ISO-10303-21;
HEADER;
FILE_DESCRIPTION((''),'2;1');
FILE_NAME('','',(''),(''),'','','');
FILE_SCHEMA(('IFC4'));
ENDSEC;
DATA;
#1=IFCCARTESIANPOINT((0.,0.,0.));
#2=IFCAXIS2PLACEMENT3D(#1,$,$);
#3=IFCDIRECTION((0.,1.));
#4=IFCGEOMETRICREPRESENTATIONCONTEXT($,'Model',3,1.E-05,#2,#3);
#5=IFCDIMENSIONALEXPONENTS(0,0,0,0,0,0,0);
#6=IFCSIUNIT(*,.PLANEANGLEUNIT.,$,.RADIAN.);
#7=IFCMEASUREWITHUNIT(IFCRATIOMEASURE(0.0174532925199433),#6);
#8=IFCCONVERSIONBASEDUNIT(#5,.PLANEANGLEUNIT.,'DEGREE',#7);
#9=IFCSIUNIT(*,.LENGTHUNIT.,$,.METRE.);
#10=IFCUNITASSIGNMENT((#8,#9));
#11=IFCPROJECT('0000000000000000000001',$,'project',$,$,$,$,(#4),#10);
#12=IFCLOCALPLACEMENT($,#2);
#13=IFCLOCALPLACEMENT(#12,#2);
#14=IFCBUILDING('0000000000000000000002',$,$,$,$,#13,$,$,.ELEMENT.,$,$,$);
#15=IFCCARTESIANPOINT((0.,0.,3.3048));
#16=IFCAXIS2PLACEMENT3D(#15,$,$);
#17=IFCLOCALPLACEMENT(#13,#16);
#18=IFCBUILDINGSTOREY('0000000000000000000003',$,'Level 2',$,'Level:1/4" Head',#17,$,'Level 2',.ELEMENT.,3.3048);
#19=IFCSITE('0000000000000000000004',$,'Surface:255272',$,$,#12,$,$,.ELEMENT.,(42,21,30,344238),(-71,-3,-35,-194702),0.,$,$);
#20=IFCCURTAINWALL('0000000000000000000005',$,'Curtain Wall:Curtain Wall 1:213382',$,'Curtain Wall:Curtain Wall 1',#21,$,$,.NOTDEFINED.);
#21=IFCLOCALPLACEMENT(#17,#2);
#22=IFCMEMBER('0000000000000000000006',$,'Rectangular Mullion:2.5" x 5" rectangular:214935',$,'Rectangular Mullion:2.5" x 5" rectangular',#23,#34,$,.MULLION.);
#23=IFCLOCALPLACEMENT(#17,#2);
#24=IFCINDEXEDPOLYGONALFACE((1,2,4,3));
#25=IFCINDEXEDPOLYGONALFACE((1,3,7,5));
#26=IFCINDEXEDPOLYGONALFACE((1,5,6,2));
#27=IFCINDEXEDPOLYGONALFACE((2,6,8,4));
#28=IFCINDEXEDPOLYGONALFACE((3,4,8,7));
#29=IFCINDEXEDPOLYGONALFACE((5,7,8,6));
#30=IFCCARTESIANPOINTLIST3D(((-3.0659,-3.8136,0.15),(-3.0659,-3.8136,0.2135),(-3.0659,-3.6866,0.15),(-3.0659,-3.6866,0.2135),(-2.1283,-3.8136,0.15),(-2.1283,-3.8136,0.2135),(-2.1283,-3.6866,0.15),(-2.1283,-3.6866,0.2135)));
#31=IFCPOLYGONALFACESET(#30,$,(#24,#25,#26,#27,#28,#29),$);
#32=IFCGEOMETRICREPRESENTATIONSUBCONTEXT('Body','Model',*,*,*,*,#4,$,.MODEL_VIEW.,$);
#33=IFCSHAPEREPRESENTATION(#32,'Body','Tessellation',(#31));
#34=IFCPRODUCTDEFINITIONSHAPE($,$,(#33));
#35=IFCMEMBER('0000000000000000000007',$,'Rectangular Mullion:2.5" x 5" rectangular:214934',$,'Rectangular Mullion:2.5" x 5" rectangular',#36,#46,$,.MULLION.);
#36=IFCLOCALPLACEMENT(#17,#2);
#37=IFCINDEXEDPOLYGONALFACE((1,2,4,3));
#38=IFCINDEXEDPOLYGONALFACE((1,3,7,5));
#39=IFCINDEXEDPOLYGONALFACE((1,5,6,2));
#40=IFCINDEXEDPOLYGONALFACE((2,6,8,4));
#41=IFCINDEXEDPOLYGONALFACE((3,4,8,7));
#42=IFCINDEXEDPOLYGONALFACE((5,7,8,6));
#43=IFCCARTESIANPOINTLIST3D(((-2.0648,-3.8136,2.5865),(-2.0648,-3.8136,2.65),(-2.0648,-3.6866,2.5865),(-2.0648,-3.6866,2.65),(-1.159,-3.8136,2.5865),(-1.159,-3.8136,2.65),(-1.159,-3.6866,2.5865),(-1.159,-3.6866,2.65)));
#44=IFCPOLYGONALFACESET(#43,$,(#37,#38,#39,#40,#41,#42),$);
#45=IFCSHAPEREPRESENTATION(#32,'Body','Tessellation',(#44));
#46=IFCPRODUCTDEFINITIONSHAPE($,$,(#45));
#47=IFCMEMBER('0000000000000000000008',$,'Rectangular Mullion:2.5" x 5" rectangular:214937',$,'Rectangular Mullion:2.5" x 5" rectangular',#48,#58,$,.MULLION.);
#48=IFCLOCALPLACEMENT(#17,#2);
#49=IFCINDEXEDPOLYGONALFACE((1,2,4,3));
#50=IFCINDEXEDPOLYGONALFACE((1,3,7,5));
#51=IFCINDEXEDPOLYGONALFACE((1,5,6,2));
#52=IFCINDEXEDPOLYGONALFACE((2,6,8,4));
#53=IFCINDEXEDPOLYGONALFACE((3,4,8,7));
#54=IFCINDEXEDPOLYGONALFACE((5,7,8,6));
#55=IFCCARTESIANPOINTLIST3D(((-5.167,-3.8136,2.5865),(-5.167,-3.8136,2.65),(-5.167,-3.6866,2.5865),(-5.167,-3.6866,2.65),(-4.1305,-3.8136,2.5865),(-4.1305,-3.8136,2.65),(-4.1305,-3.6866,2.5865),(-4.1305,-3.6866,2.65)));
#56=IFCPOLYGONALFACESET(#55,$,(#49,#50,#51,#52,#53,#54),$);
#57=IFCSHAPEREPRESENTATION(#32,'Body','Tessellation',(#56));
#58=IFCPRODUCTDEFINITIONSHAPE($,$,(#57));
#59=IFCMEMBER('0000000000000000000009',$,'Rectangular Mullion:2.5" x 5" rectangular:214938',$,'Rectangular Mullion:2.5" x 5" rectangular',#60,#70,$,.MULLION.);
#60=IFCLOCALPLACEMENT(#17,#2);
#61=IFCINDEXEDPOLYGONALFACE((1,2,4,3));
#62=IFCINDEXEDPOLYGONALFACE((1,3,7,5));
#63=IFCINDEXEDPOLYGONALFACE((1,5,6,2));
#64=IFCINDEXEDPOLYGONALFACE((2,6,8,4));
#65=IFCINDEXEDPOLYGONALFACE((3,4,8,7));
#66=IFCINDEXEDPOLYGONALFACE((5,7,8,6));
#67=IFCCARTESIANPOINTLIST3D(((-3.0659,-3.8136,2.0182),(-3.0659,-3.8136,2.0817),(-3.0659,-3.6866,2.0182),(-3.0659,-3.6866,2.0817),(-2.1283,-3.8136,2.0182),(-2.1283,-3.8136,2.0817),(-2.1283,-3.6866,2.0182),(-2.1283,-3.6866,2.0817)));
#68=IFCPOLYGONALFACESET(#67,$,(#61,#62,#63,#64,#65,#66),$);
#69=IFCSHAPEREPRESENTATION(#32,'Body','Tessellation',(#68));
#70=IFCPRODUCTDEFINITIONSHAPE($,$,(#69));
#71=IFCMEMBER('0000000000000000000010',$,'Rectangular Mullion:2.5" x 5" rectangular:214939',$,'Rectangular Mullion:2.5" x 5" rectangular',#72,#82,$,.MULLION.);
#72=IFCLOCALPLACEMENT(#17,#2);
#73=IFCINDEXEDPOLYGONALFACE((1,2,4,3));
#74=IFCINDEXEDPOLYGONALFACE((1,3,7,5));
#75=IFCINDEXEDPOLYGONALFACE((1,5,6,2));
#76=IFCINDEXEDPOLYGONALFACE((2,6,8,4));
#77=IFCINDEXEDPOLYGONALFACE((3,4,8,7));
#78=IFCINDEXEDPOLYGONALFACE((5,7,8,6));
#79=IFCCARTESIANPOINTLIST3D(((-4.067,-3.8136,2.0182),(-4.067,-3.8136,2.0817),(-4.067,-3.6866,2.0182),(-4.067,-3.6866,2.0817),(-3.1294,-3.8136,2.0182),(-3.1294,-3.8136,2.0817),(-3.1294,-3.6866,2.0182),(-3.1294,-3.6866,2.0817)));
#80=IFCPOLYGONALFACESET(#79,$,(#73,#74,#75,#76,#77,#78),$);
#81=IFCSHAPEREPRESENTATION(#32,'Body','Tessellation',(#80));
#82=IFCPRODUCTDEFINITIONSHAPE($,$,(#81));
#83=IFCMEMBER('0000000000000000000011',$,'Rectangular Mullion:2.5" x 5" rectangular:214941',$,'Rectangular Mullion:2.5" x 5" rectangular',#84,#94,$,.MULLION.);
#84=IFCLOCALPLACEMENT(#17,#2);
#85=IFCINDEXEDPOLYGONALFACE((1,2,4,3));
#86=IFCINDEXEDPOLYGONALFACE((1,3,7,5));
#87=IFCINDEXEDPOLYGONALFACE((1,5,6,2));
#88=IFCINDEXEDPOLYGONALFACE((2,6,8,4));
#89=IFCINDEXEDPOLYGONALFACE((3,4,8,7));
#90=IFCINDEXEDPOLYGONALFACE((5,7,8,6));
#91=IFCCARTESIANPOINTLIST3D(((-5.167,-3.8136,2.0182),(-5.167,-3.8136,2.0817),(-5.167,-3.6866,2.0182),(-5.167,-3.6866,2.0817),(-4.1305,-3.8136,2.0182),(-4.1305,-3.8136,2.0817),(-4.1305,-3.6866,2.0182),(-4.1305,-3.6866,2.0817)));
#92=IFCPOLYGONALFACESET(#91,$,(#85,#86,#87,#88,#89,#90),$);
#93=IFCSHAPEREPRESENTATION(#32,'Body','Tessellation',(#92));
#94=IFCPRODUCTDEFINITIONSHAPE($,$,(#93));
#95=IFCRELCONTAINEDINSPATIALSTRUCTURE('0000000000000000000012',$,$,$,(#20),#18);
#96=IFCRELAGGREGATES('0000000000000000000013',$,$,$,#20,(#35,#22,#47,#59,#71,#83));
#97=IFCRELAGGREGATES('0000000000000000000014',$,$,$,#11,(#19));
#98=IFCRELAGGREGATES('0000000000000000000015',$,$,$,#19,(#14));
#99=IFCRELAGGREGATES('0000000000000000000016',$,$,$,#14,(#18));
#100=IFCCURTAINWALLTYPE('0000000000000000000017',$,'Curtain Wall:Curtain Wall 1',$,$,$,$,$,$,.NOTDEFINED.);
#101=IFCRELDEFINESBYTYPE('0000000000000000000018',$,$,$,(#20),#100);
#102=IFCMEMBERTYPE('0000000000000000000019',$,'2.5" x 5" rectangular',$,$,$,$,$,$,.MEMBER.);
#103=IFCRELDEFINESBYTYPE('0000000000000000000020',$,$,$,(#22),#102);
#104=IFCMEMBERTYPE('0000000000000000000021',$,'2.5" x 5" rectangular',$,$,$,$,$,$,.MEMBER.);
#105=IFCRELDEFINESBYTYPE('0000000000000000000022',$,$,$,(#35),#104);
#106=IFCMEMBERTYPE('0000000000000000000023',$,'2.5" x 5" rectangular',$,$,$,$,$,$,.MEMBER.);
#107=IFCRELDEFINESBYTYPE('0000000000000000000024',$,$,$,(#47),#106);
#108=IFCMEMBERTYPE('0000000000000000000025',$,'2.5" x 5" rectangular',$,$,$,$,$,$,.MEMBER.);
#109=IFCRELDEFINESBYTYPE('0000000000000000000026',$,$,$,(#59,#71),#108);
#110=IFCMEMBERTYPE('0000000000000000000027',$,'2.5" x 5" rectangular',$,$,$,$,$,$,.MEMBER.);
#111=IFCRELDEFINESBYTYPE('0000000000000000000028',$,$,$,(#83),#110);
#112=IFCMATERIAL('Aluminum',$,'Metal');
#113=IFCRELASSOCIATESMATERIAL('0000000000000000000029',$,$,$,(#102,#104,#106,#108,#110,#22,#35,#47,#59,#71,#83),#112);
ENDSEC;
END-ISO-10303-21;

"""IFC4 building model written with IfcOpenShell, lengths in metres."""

from ifc_helpers import new_model, entity, si_unit, converted_unit, direction, frame, origin, origin_2d_with_axis, place, context, subcontext, project, spatial, rectangle, extrude, source, transform, mapped, material, material_profile, profile_set, profile_usage, type_object, type_shapes, element, aggregate, save


model = new_model("IFC4")

# Units and contexts
model_context = context("Model", 3, precision=1e-05, world=origin(), true_north=direction((0.0, 1.0)))
body_context = subcontext(model_context, "Body", "Model", "MODEL_VIEW")
ifc_project = project(units=[converted_unit("PLANEANGLEUNIT", "DEGREE", entity("IfcRatioMeasure", 0.0174532925199433), si_unit("PLANEANGLEUNIT", "RADIAN"), dimensions=[0, 0, 0, 0, 0, 0, 0]), si_unit("LENGTHUNIT", "METRE")], contexts=[model_context])

# Site, building, storey
site_placement = place(None, origin())
site = spatial("IfcSite", under=ifc_project, at=site_placement, Name="Surface:255272", CompositionType="ELEMENT", RefLatitude=(42, 21, 30, 344238), RefLongitude=(-71, -3, -35, -194702), RefElevation=0.0)
building_placement = place(site_placement, origin())
building = spatial("IfcBuilding", under=site, at=building_placement, CompositionType="ELEMENT")
storey_placement = place(building_placement, frame((0.0, 0.0, 3.3048)))
storey = spatial("IfcBuildingStorey", under=building, at=storey_placement, Name="Level 2", ObjectType="Level:1/4\" Head", LongName="Level 2", CompositionType="ELEMENT", Elevation=3.3048)

# Curtain wall, members
curtain_wall_type = type_object("IfcCurtainWallType", Name="Curtain Wall:Curtain Wall 1", PredefinedType="NOTDEFINED")
curtain_wall_placement = place(storey_placement, frame((0.0, 0.0, -3.3048)))
curtain_wall = element("IfcCurtainWall", 1, at=curtain_wall_placement, inside=storey, type_object=curtain_wall_type, Name="Curtain Wall:Curtain Wall 1:213382", ObjectType="Curtain Wall:Curtain Wall 1", PredefinedType="NOTDEFINED")
ifc_material_1 = material(Name="Aluminum", Category="Metal")
ifc_material_profile = material_profile(ifc_material_1, rectangle(XDim=0.127, YDim=0.0635, at=origin_2d_with_axis()), Name="2.5\" x 5\" rectangular")
ifc_profile_set = profile_set([ifc_material_profile], Name="2.5\" x 5\" rectangular")
member_type_1 = type_object("IfcMemberType", Name="2.5\" x 5\" rectangular", PredefinedType="MEMBER", material=ifc_profile_set)
shared_shape_1 = source(origin(), body_context, "Body", "SweptSolid", [
    extrude(rectangle(XDim=0.127, YDim=0.0635, at=origin_2d_with_axis()), frame((-0.0318, 0.0, -0.9376), z_axis=(0.0, 0.0, 1.0), x_axis=(0.0, -1.0, 0.0)), (0.0, 0.0, 1.0), 0.9376),
])
type_shapes(member_type_1, [shared_shape_1])
ifc_profile_usage_1 = profile_usage(ifc_profile_set)
member_1_placement = place(storey_placement, frame((-2.1283, -3.7501, 0.15), z_axis=(1.0, -0.000007, 0.0), x_axis=(0.0, 0.0, -1.0)))
member_1 = element("IfcMember", 2, at=member_1_placement, type_object=member_type_1, material=ifc_profile_usage_1, Name="Rectangular Mullion:2.5\" x 5\" rectangular:214935", ObjectType="Rectangular Mullion:2.5\" x 5\" rectangular", PredefinedType="MULLION", context=body_context, shape_type="MappedRepresentation", body=[
    mapped(shared_shape_1, transform((0.0, 0.0, 0.0), scale=1.0)),
])
ifc_profile_usage_2 = profile_usage(ifc_profile_set)
member_type_2 = type_object("IfcMemberType", Name="2.5\" x 5\" rectangular", PredefinedType="MEMBER", material=ifc_profile_set)
shared_shape_2 = source(origin(), body_context, "Body", "SweptSolid", [
    extrude(rectangle(XDim=0.127, YDim=0.0635, at=origin_2d_with_axis()), frame((-0.0318, 0.0, -0.9058), z_axis=(0.0, 0.0, 1.0), x_axis=(0.0, -1.0, 0.0)), (0.0, 0.0, 1.0), 0.9058),
])
type_shapes(member_type_2, [shared_shape_2])
member_2_placement = place(storey_placement, frame((-2.0648, -3.7501, 2.65), z_axis=(-1.0, 0.000007, 0.0), x_axis=(0.0, 0.0, 1.0)))
member_2 = element("IfcMember", 3, at=member_2_placement, type_object=member_type_2, material=ifc_profile_usage_2, Name="Rectangular Mullion:2.5\" x 5\" rectangular:214934", ObjectType="Rectangular Mullion:2.5\" x 5\" rectangular", PredefinedType="MULLION", context=body_context, shape_type="MappedRepresentation", body=[
    mapped(shared_shape_2, transform((0.0, 0.0, 0.0), scale=1.0)),
])
ifc_profile_usage_3 = profile_usage(ifc_profile_set)
member_type_3 = type_object("IfcMemberType", Name="2.5\" x 5\" rectangular", PredefinedType="MEMBER", material=ifc_profile_set)
shared_shape_3 = source(origin(), body_context, "Body", "SweptSolid", [
    extrude(rectangle(XDim=0.127, YDim=0.0635, at=origin_2d_with_axis()), frame((-0.0318, 0.0, -1.0365), z_axis=(0.0, 0.0, 1.0), x_axis=(0.0, -1.0, 0.0)), (0.0, 0.0, 1.0), 1.0365),
])
type_shapes(member_type_3, [shared_shape_3])
member_3_placement = place(storey_placement, frame((-5.167, -3.7501, 2.65), z_axis=(-1.0, 0.000007, 0.0), x_axis=(0.0, 0.0, 1.0)))
member_3 = element("IfcMember", 4, at=member_3_placement, type_object=member_type_3, material=ifc_profile_usage_3, Name="Rectangular Mullion:2.5\" x 5\" rectangular:214937", ObjectType="Rectangular Mullion:2.5\" x 5\" rectangular", PredefinedType="MULLION", context=body_context, shape_type="MappedRepresentation", body=[
    mapped(shared_shape_3, transform((0.0, 0.0, 0.0), scale=1.0)),
])
ifc_profile_usage_4 = profile_usage(ifc_profile_set)
member_type_4 = type_object("IfcMemberType", Name="2.5\" x 5\" rectangular", PredefinedType="MEMBER", material=ifc_profile_set)
shared_shape_4 = source(origin(), body_context, "Body", "SweptSolid", [
    extrude(rectangle(XDim=0.127, YDim=0.0635, at=origin_2d_with_axis()), frame((0.0, 0.0, -0.9376), z_axis=(0.0, 0.0, 1.0), x_axis=(0.0, -1.0, 0.0)), (0.0, 0.0, 1.0), 0.9376),
])
type_shapes(member_type_4, [shared_shape_4])
member_4_placement = place(storey_placement, frame((-3.0659, -3.7501, 2.05), z_axis=(-1.0, 0.000007, 0.0), x_axis=(0.0, 0.0, 1.0)))
member_4 = element("IfcMember", 5, at=member_4_placement, type_object=member_type_4, material=ifc_profile_usage_4, Name="Rectangular Mullion:2.5\" x 5\" rectangular:214938", ObjectType="Rectangular Mullion:2.5\" x 5\" rectangular", PredefinedType="MULLION", context=body_context, shape_type="MappedRepresentation", body=[
    mapped(shared_shape_4, transform((0.0, 0.0, 0.0), scale=1.0)),
])
ifc_profile_usage_5 = profile_usage(ifc_profile_set)
member_5_placement = place(storey_placement, frame((-4.067, -3.7501, 2.05), z_axis=(-1.0, 0.000007, 0.0), x_axis=(0.0, 0.0, 1.0)))
member_5 = element("IfcMember", 6, at=member_5_placement, type_object=member_type_4, material=ifc_profile_usage_5, Name="Rectangular Mullion:2.5\" x 5\" rectangular:214939", ObjectType="Rectangular Mullion:2.5\" x 5\" rectangular", PredefinedType="MULLION", context=body_context, shape_type="MappedRepresentation", body=[
    mapped(shared_shape_4, transform((0.0, 0.0, 0.0), scale=1.0)),
])
ifc_profile_usage_6 = profile_usage(ifc_profile_set)
member_type_5 = type_object("IfcMemberType", Name="2.5\" x 5\" rectangular", PredefinedType="MEMBER", material=ifc_profile_set)
shared_shape_5 = source(origin(), body_context, "Body", "SweptSolid", [
    extrude(rectangle(XDim=0.127, YDim=0.0635, at=origin_2d_with_axis()), frame((0.0, 0.0, -1.0365), z_axis=(0.0, 0.0, 1.0), x_axis=(0.0, -1.0, 0.0)), (0.0, 0.0, 1.0), 1.0365),
])
type_shapes(member_type_5, [shared_shape_5])
member_6_placement = place(storey_placement, frame((-5.167, -3.7501, 2.05), z_axis=(-1.0, 0.000007, 0.0), x_axis=(0.0, 0.0, 1.0)))
member_6 = element("IfcMember", 7, at=member_6_placement, type_object=member_type_5, material=ifc_profile_usage_6, Name="Rectangular Mullion:2.5\" x 5\" rectangular:214941", ObjectType="Rectangular Mullion:2.5\" x 5\" rectangular", PredefinedType="MULLION", context=body_context, shape_type="MappedRepresentation", body=[
    mapped(shared_shape_5, transform((0.0, 0.0, 0.0), scale=1.0)),
])
aggregate(curtain_wall, [member_2, member_1, member_3, member_4, member_5, member_6])

save(model, "model.ifc")
